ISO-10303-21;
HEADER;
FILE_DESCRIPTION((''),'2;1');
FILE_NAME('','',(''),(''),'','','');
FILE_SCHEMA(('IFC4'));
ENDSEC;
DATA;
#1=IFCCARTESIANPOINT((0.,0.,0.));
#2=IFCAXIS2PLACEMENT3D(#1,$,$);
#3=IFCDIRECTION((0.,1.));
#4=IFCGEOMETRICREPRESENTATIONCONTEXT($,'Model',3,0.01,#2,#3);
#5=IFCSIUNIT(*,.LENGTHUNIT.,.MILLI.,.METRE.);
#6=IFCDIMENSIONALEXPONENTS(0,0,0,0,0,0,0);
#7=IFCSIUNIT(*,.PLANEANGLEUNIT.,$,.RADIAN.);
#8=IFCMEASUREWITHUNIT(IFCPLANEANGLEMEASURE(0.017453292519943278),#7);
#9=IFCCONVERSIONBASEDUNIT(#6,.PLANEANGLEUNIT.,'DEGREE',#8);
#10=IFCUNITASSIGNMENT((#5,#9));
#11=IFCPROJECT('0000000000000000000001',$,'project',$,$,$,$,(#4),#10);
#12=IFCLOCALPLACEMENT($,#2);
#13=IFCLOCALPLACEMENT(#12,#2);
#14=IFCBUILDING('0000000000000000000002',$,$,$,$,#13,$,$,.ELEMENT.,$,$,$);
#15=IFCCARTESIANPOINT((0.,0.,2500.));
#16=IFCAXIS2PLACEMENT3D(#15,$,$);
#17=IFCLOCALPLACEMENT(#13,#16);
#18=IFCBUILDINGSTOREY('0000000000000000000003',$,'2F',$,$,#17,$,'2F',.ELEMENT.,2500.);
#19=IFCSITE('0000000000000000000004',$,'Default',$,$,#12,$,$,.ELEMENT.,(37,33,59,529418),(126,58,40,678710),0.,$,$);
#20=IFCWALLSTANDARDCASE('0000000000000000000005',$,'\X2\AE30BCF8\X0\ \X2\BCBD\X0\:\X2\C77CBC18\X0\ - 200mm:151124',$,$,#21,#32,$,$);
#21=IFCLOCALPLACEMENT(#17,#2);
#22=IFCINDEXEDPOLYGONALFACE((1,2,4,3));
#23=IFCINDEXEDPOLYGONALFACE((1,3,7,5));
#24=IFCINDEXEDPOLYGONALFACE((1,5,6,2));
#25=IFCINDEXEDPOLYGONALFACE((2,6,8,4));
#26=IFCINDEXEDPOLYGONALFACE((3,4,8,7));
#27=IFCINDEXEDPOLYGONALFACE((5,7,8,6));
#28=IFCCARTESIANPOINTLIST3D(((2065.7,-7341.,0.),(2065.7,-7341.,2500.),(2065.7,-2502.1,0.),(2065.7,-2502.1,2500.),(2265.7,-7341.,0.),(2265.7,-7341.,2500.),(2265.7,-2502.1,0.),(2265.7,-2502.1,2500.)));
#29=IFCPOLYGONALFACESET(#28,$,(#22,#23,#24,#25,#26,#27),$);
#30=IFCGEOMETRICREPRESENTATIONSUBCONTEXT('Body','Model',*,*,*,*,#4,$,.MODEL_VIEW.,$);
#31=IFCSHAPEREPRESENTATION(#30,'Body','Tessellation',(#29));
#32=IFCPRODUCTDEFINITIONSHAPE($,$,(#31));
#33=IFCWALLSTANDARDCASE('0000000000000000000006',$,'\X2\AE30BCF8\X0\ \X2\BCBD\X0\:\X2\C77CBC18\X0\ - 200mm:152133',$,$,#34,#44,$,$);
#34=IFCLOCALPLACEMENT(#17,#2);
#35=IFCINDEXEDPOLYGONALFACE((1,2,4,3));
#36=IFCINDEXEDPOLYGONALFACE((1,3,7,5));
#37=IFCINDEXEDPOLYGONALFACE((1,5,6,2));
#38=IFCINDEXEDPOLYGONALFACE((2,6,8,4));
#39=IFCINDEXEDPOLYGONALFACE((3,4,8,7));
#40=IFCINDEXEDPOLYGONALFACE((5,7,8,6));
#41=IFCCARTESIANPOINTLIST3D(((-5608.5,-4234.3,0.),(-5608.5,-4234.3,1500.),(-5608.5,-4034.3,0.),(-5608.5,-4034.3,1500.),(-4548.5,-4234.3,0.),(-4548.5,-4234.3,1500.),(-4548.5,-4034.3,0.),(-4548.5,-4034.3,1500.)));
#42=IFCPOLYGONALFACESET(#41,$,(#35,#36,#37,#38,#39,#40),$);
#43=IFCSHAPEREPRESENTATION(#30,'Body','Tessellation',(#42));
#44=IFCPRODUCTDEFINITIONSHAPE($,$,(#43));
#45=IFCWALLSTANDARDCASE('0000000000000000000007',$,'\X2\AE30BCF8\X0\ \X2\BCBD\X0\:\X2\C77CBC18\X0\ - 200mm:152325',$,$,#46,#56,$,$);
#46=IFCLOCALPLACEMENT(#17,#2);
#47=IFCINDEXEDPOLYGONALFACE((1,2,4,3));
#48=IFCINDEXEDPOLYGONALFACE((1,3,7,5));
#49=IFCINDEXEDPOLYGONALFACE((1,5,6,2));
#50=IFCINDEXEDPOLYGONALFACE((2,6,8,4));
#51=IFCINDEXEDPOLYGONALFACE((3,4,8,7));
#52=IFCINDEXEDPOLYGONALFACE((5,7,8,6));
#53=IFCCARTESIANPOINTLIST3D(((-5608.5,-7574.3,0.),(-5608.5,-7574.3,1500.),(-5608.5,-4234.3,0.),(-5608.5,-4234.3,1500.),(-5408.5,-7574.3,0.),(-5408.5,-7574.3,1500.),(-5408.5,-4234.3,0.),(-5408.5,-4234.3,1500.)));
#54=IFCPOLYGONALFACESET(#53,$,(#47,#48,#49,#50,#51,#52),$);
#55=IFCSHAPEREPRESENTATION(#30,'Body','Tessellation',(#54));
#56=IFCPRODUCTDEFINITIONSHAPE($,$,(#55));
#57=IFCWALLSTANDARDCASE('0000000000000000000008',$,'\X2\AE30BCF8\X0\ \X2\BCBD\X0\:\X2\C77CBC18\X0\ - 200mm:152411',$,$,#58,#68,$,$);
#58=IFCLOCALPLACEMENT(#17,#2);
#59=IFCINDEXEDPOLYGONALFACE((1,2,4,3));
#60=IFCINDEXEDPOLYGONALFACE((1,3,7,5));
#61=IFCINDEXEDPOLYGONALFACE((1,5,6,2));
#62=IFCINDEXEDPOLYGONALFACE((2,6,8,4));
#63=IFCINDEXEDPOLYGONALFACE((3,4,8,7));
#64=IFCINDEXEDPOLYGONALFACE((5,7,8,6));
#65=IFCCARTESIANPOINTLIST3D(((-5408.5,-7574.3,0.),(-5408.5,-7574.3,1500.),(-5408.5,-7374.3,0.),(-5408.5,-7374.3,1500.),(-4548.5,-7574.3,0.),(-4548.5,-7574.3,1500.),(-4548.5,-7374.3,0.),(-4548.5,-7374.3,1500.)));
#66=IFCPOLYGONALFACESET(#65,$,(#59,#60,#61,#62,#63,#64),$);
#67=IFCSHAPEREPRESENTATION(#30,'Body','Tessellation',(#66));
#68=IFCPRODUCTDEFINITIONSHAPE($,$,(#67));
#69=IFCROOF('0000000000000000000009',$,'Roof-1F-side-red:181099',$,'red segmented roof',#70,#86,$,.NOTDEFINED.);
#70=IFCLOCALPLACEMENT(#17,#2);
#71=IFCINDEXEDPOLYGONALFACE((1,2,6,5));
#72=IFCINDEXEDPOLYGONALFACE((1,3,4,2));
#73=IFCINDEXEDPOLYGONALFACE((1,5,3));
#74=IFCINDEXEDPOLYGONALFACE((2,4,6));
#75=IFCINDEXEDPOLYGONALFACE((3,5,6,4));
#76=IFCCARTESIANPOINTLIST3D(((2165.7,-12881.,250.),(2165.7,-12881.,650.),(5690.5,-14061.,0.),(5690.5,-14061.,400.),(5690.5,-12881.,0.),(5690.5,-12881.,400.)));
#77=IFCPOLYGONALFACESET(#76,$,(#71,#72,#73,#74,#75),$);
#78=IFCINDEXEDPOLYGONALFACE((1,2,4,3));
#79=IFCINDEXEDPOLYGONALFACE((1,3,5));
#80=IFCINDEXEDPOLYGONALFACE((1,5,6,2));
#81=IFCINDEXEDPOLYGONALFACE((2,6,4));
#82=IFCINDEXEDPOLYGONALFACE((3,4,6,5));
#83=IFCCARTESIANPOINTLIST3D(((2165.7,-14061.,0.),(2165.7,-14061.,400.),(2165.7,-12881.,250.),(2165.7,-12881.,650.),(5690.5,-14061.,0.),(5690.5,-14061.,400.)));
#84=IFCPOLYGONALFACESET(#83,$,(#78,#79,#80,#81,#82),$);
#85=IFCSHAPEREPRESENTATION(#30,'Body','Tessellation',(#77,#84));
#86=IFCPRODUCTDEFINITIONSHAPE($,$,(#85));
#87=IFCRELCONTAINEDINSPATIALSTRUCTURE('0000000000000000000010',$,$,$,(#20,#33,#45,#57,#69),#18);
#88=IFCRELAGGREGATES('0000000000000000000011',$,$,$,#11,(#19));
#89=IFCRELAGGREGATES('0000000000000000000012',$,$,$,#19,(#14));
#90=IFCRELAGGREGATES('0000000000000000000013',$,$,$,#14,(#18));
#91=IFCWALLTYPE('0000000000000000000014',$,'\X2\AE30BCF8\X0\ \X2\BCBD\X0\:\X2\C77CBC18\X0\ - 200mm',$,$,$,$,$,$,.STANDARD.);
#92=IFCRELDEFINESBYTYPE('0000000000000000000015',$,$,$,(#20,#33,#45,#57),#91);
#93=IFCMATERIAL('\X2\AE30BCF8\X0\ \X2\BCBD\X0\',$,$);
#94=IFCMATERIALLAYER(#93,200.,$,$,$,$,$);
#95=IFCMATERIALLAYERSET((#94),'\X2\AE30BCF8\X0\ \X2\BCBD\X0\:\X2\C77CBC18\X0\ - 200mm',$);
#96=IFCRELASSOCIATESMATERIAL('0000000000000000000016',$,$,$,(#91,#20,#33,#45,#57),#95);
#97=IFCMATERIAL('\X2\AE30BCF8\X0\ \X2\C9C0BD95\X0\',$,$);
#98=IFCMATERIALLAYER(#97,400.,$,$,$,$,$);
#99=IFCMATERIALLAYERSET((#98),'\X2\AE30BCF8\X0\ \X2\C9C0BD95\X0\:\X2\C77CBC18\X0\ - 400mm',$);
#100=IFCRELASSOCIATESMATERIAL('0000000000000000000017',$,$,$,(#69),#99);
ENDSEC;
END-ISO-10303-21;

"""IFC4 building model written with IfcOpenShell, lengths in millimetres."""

from ifc_helpers import new_model, entity, si_unit, converted_unit, direction, frame, frame_2d, origin, origin_with_axes, place, context, subcontext, project, spatial, polyline, rectangle, outline, extrude, source, transform, mapped, material, layer, layer_set, layer_usage, type_object, element, save


model = new_model("IFC4")

# Units and contexts
model_context = context("Model", 3, precision=0.01, world=origin(), true_north=direction((0.0, 1.0)))
body_context = subcontext(model_context, "Body", "Model", "MODEL_VIEW")
ifc_project = project(units=[si_unit("LENGTHUNIT", "METRE", prefix="MILLI"), converted_unit("PLANEANGLEUNIT", "DEGREE", entity("IfcPlaneAngleMeasure", 0.017453292519943278), si_unit("PLANEANGLEUNIT", "RADIAN"), dimensions=[0, 0, 0, 0, 0, 0, 0])], contexts=[model_context])

# Site, building, storey
site_placement = place(None, origin())
site = spatial("IfcSite", under=ifc_project, at=site_placement, Name="Default", CompositionType="ELEMENT", RefLatitude=(37, 33, 59, 529418), RefLongitude=(126, 58, 40, 678710), RefElevation=0.0)
building_placement = place(site_placement, origin())
building = spatial("IfcBuilding", under=site, at=building_placement, CompositionType="ELEMENT")
storey_placement = place(building_placement, frame((0.0, 0.0, 2500.0)))
storey = spatial("IfcBuildingStorey", under=building, at=storey_placement, Name="2F", LongName="2F", CompositionType="ELEMENT", Elevation=2500.0)

# Shared definitions
ifc_material_1 = material(Name="기본 벽")
ifc_layer_1 = layer(ifc_material_1, 200.0)
ifc_layer_set_1 = layer_set([ifc_layer_1], Name="기본 벽:일반 - 200mm")
wall_type = type_object("IfcWallType", Name="기본 벽:일반 - 200mm", PredefinedType="STANDARD", material=ifc_layer_set_1)

# Walls
ifc_layer_usage_1 = layer_usage(ifc_layer_set_1, "AXIS2", "NEGATIVE", 100.0)
wall_1_placement = place(storey_placement, frame((2165.7, -7341.0, 0.0), z_axis=(0.0, 0.0, 1.0), x_axis=(0.0, 1.0, 0.0)))
element("IfcWallStandardCase", 1, at=wall_1_placement, inside=storey, type_object=wall_type, material=ifc_layer_usage_1, Name="기본 벽:일반 - 200mm:151124", context=body_context, shape_type="SweptSolid", body=[
    extrude(rectangle(XDim=4838.9, YDim=200.0, at=frame_2d((2419.4, 0.0), x_axis=(-1.0, 0.0))), origin(), (0.0, 0.0, 1.0), 2500.0),
])
ifc_layer_usage_2 = layer_usage(ifc_layer_set_1, "AXIS2", "NEGATIVE", 100.0)
wall_2_placement = place(storey_placement, frame((-4548.5, -4134.3, 0.0), z_axis=(0.0, 0.0, 1.0), x_axis=(-1.0, 0.0, 0.0)))
element("IfcWallStandardCase", 2, at=wall_2_placement, inside=storey, type_object=wall_type, material=ifc_layer_usage_2, Name="기본 벽:일반 - 200mm:152133", context=body_context, shape_type="SweptSolid", body=[
    extrude(rectangle(XDim=1060.0, YDim=200.0, at=frame_2d((530.0, 0.0), x_axis=(-1.0, 0.0))), origin(), (0.0, 0.0, 1.0), 1500.0),
])
ifc_layer_usage_3 = layer_usage(ifc_layer_set_1, "AXIS2", "NEGATIVE", 100.0)
wall_3_placement = place(storey_placement, frame((-5508.5, -4234.3, 0.0), z_axis=(0.0, 0.0, 1.0), x_axis=(0.0, -1.0, 0.0)))
element("IfcWallStandardCase", 3, at=wall_3_placement, inside=storey, type_object=wall_type, material=ifc_layer_usage_3, Name="기본 벽:일반 - 200mm:152325", context=body_context, shape_type="SweptSolid", body=[
    extrude(rectangle(XDim=3340.0, YDim=200.0, at=frame_2d((1670.0, 0.0), x_axis=(-1.0, 0.0))), origin(), (0.0, 0.0, 1.0), 1500.0),
])
ifc_layer_usage_4 = layer_usage(ifc_layer_set_1, "AXIS2", "NEGATIVE", 100.0)
wall_4_placement = place(storey_placement, frame((-5408.5, -7474.3, 0.0)))
element("IfcWallStandardCase", 4, at=wall_4_placement, inside=storey, type_object=wall_type, material=ifc_layer_usage_4, Name="기본 벽:일반 - 200mm:152411", context=body_context, shape_type="SweptSolid", body=[
    extrude(rectangle(XDim=860.0, YDim=200.0, at=frame_2d((430.0, 0.0), x_axis=(-1.0, 0.0))), origin(), (0.0, 0.0, 1.0), 1500.0),
])

# Roof
ifc_material_2 = material(Name="기본 지붕")
ifc_layer_2 = layer(ifc_material_2, 400.0)
ifc_layer_set_2 = layer_set([ifc_layer_2], Name="기본 지붕:일반 - 400mm")
shared_shape_1 = source(origin_with_axes(), body_context, "Body", "SweptSolid", [
    extrude(outline(polyline([(1766.8, 590.0), (-1766.8, 590.0), (1766.8, -590.0), (1766.8, 590.0)])), frame((1762.4, 590.0, 125.0), z_axis=(0.070749, 0.0, 0.997494), x_axis=(0.997494, 0.0, -0.070749)), (-0.070749, 0.0, 0.997494), 400.0),
])
shared_shape_2 = source(origin_with_axes(), body_context, "Body", "SweptSolid", [
    extrude(outline(polyline([(-1762.4, 603.1), (-1762.4, -603.1), (1762.4, -603.1), (-1762.4, 603.1)])), frame((1762.4, 590.0, 125.0), z_axis=(0.0, -0.207264, 0.978285), x_axis=(1.0, 0.0, 0.0)), (0.0, 0.207264, 0.978285), 400.0),
])
roof_1_placement = place(storey_placement, frame((2165.7, -14061.0, 0.0)))
element("IfcRoof", 5, at=roof_1_placement, inside=storey, material=ifc_layer_set_2, Name="Roof-1F-side-red:181099", ObjectType="red segmented roof", PredefinedType="NOTDEFINED", context=body_context, shape_type="MappedRepresentation", body=[
    mapped(shared_shape_1, transform((0.0, 0.0, 0.0), x_axis=(1.0, 0.0, 0.0), y_axis=(0.0, 1.0, 0.0), z_axis=(0.0, 0.0, 1.0), scale=1.0)),
    mapped(shared_shape_2, transform((0.0, 0.0, 0.0), x_axis=(1.0, 0.0, 0.0), y_axis=(0.0, 1.0, 0.0), z_axis=(0.0, 0.0, 1.0), scale=1.0)),
])

save(model, "model.ifc")
